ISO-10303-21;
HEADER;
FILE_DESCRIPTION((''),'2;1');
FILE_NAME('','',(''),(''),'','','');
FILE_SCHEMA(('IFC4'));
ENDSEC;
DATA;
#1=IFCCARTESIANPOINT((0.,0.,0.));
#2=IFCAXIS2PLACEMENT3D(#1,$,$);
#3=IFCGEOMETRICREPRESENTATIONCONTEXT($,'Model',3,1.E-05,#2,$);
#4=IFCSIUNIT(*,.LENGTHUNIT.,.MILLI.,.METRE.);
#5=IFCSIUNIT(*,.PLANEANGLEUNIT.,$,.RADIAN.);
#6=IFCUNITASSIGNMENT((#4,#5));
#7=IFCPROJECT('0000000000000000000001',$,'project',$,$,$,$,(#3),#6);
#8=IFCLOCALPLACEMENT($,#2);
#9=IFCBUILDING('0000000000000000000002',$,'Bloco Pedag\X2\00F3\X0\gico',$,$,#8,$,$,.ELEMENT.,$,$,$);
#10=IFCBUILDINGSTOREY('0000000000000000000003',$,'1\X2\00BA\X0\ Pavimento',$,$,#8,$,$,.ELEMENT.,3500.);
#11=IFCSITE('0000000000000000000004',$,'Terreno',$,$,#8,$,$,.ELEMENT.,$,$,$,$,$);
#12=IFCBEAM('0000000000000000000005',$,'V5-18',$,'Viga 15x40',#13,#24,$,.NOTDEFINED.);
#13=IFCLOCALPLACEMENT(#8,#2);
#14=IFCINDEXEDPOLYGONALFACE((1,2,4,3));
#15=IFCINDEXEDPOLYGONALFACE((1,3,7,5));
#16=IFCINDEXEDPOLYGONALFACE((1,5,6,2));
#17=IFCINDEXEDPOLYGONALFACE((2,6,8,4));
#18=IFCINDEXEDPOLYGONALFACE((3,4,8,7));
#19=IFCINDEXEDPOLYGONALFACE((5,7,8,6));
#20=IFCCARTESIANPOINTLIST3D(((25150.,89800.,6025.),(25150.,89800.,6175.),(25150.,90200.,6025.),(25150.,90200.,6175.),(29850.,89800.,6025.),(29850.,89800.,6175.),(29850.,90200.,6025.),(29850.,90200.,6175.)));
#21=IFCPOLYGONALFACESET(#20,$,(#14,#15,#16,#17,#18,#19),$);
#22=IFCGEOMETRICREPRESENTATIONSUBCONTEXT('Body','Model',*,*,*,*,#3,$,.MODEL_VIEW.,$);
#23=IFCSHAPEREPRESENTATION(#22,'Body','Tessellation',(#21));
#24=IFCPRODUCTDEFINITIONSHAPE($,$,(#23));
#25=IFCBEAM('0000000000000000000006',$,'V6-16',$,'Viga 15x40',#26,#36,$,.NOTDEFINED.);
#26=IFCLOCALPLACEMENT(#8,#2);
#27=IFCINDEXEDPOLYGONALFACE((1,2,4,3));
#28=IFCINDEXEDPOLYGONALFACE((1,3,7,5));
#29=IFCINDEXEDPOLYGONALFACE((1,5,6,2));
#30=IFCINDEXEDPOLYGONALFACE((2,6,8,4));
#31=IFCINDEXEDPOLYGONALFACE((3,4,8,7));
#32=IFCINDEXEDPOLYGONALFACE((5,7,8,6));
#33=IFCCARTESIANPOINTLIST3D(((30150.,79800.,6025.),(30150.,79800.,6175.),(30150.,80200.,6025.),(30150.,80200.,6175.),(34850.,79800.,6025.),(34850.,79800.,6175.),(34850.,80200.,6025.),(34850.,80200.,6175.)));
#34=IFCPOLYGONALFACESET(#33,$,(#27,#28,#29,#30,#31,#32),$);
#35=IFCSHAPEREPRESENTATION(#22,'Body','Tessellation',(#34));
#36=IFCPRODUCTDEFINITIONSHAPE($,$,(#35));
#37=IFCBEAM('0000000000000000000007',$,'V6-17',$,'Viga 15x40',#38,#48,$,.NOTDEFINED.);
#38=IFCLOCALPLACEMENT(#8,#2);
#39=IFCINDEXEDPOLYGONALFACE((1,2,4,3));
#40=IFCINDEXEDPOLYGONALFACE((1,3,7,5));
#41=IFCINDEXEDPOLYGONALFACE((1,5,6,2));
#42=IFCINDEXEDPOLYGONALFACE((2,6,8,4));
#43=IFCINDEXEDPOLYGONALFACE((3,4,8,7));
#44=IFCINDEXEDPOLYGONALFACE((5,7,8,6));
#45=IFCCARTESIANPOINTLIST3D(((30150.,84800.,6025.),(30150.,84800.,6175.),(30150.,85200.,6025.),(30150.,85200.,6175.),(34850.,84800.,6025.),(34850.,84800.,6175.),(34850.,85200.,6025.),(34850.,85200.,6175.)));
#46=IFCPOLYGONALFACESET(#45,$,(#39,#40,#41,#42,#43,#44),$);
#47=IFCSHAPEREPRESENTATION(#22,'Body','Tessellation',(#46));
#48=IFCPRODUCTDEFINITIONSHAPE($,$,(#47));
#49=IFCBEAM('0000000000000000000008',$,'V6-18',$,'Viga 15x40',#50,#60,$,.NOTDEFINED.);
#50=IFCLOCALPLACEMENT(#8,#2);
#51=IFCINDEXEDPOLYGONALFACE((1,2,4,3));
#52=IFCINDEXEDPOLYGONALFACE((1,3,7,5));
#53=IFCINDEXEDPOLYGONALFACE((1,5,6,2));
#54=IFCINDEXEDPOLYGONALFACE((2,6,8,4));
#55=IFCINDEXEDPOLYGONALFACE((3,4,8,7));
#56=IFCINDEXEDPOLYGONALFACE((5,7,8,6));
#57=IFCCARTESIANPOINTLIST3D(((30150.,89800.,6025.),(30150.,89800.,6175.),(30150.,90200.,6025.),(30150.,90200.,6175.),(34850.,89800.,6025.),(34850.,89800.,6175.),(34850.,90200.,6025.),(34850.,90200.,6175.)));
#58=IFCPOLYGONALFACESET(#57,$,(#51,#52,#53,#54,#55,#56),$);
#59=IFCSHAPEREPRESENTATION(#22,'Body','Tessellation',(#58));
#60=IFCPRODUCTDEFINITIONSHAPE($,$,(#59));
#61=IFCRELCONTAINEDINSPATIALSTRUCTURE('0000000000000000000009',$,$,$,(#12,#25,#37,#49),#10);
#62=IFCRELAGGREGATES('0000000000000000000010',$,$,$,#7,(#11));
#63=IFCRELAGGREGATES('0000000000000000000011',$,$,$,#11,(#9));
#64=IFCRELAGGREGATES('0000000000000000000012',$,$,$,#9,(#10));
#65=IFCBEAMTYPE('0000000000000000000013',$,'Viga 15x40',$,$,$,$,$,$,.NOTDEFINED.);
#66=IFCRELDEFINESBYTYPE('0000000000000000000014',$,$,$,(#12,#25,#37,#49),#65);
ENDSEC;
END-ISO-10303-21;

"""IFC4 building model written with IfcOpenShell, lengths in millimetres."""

from ifc_helpers import new_model, si_unit, frame, origin, origin_2d, place, context, subcontext, project, spatial, rectangle, extrude, type_object, element, save


model = new_model("IFC4")

# Units and contexts
model_context = context("Model", 3, precision=1e-05, world=origin())
body_context = subcontext(model_context, "Body", "Model", "MODEL_VIEW")
ifc_project = project(units=[si_unit("LENGTHUNIT", "METRE", prefix="MILLI"), si_unit("PLANEANGLEUNIT", "RADIAN")], contexts=[model_context])

# Site, building, storey
placement = place(None, origin())
site = spatial("IfcSite", under=ifc_project, at=placement, Name="Terreno", CompositionType="ELEMENT")
building = spatial("IfcBuilding", under=site, at=placement, Name="Bloco Pedagógico", CompositionType="ELEMENT")
storey = spatial("IfcBuildingStorey", under=building, at=placement, Name="1º Pavimento", CompositionType="ELEMENT", Elevation=3500.0)

# Beams
beam_type = type_object("IfcBeamType", Name="Viga 15x40", PredefinedType="NOTDEFINED")
for number, where, z_axis, x_axis, name in (
    (1, (25150.0, 90000.0, 6100.0), (1.0, 0.0, 0.0), (0.0, 1.0, 0.0), "V5-18"),
    (2, (30150.0, 80000.0, 6100.0), (1.0, 0.0, 0.0), (0.0, 1.0, 0.0), "V6-16"),
    (3, (30150.0, 85000.0, 6100.0), (1.0, 0.0, 0.0), (0.0, 1.0, 0.0), "V6-17"),
    (4, (30150.0, 90000.0, 6100.0), (1.0, 0.0, 0.0), (0.0, 1.0, 0.0), "V6-18"),
):
    element("IfcBeam", number, at=place(None, frame(where, z_axis=z_axis, x_axis=x_axis)), inside=storey, type_object=beam_type, Name=name, ObjectType="Viga 15x40", PredefinedType="NOTDEFINED", context=body_context, shape_type="SweptSolid", body=[
        extrude(rectangle(XDim=400.0, YDim=150.0, at=origin_2d()), None, (0.0, 0.0, 1.0), 4700.0),
    ])

save(model, "model.ifc")
